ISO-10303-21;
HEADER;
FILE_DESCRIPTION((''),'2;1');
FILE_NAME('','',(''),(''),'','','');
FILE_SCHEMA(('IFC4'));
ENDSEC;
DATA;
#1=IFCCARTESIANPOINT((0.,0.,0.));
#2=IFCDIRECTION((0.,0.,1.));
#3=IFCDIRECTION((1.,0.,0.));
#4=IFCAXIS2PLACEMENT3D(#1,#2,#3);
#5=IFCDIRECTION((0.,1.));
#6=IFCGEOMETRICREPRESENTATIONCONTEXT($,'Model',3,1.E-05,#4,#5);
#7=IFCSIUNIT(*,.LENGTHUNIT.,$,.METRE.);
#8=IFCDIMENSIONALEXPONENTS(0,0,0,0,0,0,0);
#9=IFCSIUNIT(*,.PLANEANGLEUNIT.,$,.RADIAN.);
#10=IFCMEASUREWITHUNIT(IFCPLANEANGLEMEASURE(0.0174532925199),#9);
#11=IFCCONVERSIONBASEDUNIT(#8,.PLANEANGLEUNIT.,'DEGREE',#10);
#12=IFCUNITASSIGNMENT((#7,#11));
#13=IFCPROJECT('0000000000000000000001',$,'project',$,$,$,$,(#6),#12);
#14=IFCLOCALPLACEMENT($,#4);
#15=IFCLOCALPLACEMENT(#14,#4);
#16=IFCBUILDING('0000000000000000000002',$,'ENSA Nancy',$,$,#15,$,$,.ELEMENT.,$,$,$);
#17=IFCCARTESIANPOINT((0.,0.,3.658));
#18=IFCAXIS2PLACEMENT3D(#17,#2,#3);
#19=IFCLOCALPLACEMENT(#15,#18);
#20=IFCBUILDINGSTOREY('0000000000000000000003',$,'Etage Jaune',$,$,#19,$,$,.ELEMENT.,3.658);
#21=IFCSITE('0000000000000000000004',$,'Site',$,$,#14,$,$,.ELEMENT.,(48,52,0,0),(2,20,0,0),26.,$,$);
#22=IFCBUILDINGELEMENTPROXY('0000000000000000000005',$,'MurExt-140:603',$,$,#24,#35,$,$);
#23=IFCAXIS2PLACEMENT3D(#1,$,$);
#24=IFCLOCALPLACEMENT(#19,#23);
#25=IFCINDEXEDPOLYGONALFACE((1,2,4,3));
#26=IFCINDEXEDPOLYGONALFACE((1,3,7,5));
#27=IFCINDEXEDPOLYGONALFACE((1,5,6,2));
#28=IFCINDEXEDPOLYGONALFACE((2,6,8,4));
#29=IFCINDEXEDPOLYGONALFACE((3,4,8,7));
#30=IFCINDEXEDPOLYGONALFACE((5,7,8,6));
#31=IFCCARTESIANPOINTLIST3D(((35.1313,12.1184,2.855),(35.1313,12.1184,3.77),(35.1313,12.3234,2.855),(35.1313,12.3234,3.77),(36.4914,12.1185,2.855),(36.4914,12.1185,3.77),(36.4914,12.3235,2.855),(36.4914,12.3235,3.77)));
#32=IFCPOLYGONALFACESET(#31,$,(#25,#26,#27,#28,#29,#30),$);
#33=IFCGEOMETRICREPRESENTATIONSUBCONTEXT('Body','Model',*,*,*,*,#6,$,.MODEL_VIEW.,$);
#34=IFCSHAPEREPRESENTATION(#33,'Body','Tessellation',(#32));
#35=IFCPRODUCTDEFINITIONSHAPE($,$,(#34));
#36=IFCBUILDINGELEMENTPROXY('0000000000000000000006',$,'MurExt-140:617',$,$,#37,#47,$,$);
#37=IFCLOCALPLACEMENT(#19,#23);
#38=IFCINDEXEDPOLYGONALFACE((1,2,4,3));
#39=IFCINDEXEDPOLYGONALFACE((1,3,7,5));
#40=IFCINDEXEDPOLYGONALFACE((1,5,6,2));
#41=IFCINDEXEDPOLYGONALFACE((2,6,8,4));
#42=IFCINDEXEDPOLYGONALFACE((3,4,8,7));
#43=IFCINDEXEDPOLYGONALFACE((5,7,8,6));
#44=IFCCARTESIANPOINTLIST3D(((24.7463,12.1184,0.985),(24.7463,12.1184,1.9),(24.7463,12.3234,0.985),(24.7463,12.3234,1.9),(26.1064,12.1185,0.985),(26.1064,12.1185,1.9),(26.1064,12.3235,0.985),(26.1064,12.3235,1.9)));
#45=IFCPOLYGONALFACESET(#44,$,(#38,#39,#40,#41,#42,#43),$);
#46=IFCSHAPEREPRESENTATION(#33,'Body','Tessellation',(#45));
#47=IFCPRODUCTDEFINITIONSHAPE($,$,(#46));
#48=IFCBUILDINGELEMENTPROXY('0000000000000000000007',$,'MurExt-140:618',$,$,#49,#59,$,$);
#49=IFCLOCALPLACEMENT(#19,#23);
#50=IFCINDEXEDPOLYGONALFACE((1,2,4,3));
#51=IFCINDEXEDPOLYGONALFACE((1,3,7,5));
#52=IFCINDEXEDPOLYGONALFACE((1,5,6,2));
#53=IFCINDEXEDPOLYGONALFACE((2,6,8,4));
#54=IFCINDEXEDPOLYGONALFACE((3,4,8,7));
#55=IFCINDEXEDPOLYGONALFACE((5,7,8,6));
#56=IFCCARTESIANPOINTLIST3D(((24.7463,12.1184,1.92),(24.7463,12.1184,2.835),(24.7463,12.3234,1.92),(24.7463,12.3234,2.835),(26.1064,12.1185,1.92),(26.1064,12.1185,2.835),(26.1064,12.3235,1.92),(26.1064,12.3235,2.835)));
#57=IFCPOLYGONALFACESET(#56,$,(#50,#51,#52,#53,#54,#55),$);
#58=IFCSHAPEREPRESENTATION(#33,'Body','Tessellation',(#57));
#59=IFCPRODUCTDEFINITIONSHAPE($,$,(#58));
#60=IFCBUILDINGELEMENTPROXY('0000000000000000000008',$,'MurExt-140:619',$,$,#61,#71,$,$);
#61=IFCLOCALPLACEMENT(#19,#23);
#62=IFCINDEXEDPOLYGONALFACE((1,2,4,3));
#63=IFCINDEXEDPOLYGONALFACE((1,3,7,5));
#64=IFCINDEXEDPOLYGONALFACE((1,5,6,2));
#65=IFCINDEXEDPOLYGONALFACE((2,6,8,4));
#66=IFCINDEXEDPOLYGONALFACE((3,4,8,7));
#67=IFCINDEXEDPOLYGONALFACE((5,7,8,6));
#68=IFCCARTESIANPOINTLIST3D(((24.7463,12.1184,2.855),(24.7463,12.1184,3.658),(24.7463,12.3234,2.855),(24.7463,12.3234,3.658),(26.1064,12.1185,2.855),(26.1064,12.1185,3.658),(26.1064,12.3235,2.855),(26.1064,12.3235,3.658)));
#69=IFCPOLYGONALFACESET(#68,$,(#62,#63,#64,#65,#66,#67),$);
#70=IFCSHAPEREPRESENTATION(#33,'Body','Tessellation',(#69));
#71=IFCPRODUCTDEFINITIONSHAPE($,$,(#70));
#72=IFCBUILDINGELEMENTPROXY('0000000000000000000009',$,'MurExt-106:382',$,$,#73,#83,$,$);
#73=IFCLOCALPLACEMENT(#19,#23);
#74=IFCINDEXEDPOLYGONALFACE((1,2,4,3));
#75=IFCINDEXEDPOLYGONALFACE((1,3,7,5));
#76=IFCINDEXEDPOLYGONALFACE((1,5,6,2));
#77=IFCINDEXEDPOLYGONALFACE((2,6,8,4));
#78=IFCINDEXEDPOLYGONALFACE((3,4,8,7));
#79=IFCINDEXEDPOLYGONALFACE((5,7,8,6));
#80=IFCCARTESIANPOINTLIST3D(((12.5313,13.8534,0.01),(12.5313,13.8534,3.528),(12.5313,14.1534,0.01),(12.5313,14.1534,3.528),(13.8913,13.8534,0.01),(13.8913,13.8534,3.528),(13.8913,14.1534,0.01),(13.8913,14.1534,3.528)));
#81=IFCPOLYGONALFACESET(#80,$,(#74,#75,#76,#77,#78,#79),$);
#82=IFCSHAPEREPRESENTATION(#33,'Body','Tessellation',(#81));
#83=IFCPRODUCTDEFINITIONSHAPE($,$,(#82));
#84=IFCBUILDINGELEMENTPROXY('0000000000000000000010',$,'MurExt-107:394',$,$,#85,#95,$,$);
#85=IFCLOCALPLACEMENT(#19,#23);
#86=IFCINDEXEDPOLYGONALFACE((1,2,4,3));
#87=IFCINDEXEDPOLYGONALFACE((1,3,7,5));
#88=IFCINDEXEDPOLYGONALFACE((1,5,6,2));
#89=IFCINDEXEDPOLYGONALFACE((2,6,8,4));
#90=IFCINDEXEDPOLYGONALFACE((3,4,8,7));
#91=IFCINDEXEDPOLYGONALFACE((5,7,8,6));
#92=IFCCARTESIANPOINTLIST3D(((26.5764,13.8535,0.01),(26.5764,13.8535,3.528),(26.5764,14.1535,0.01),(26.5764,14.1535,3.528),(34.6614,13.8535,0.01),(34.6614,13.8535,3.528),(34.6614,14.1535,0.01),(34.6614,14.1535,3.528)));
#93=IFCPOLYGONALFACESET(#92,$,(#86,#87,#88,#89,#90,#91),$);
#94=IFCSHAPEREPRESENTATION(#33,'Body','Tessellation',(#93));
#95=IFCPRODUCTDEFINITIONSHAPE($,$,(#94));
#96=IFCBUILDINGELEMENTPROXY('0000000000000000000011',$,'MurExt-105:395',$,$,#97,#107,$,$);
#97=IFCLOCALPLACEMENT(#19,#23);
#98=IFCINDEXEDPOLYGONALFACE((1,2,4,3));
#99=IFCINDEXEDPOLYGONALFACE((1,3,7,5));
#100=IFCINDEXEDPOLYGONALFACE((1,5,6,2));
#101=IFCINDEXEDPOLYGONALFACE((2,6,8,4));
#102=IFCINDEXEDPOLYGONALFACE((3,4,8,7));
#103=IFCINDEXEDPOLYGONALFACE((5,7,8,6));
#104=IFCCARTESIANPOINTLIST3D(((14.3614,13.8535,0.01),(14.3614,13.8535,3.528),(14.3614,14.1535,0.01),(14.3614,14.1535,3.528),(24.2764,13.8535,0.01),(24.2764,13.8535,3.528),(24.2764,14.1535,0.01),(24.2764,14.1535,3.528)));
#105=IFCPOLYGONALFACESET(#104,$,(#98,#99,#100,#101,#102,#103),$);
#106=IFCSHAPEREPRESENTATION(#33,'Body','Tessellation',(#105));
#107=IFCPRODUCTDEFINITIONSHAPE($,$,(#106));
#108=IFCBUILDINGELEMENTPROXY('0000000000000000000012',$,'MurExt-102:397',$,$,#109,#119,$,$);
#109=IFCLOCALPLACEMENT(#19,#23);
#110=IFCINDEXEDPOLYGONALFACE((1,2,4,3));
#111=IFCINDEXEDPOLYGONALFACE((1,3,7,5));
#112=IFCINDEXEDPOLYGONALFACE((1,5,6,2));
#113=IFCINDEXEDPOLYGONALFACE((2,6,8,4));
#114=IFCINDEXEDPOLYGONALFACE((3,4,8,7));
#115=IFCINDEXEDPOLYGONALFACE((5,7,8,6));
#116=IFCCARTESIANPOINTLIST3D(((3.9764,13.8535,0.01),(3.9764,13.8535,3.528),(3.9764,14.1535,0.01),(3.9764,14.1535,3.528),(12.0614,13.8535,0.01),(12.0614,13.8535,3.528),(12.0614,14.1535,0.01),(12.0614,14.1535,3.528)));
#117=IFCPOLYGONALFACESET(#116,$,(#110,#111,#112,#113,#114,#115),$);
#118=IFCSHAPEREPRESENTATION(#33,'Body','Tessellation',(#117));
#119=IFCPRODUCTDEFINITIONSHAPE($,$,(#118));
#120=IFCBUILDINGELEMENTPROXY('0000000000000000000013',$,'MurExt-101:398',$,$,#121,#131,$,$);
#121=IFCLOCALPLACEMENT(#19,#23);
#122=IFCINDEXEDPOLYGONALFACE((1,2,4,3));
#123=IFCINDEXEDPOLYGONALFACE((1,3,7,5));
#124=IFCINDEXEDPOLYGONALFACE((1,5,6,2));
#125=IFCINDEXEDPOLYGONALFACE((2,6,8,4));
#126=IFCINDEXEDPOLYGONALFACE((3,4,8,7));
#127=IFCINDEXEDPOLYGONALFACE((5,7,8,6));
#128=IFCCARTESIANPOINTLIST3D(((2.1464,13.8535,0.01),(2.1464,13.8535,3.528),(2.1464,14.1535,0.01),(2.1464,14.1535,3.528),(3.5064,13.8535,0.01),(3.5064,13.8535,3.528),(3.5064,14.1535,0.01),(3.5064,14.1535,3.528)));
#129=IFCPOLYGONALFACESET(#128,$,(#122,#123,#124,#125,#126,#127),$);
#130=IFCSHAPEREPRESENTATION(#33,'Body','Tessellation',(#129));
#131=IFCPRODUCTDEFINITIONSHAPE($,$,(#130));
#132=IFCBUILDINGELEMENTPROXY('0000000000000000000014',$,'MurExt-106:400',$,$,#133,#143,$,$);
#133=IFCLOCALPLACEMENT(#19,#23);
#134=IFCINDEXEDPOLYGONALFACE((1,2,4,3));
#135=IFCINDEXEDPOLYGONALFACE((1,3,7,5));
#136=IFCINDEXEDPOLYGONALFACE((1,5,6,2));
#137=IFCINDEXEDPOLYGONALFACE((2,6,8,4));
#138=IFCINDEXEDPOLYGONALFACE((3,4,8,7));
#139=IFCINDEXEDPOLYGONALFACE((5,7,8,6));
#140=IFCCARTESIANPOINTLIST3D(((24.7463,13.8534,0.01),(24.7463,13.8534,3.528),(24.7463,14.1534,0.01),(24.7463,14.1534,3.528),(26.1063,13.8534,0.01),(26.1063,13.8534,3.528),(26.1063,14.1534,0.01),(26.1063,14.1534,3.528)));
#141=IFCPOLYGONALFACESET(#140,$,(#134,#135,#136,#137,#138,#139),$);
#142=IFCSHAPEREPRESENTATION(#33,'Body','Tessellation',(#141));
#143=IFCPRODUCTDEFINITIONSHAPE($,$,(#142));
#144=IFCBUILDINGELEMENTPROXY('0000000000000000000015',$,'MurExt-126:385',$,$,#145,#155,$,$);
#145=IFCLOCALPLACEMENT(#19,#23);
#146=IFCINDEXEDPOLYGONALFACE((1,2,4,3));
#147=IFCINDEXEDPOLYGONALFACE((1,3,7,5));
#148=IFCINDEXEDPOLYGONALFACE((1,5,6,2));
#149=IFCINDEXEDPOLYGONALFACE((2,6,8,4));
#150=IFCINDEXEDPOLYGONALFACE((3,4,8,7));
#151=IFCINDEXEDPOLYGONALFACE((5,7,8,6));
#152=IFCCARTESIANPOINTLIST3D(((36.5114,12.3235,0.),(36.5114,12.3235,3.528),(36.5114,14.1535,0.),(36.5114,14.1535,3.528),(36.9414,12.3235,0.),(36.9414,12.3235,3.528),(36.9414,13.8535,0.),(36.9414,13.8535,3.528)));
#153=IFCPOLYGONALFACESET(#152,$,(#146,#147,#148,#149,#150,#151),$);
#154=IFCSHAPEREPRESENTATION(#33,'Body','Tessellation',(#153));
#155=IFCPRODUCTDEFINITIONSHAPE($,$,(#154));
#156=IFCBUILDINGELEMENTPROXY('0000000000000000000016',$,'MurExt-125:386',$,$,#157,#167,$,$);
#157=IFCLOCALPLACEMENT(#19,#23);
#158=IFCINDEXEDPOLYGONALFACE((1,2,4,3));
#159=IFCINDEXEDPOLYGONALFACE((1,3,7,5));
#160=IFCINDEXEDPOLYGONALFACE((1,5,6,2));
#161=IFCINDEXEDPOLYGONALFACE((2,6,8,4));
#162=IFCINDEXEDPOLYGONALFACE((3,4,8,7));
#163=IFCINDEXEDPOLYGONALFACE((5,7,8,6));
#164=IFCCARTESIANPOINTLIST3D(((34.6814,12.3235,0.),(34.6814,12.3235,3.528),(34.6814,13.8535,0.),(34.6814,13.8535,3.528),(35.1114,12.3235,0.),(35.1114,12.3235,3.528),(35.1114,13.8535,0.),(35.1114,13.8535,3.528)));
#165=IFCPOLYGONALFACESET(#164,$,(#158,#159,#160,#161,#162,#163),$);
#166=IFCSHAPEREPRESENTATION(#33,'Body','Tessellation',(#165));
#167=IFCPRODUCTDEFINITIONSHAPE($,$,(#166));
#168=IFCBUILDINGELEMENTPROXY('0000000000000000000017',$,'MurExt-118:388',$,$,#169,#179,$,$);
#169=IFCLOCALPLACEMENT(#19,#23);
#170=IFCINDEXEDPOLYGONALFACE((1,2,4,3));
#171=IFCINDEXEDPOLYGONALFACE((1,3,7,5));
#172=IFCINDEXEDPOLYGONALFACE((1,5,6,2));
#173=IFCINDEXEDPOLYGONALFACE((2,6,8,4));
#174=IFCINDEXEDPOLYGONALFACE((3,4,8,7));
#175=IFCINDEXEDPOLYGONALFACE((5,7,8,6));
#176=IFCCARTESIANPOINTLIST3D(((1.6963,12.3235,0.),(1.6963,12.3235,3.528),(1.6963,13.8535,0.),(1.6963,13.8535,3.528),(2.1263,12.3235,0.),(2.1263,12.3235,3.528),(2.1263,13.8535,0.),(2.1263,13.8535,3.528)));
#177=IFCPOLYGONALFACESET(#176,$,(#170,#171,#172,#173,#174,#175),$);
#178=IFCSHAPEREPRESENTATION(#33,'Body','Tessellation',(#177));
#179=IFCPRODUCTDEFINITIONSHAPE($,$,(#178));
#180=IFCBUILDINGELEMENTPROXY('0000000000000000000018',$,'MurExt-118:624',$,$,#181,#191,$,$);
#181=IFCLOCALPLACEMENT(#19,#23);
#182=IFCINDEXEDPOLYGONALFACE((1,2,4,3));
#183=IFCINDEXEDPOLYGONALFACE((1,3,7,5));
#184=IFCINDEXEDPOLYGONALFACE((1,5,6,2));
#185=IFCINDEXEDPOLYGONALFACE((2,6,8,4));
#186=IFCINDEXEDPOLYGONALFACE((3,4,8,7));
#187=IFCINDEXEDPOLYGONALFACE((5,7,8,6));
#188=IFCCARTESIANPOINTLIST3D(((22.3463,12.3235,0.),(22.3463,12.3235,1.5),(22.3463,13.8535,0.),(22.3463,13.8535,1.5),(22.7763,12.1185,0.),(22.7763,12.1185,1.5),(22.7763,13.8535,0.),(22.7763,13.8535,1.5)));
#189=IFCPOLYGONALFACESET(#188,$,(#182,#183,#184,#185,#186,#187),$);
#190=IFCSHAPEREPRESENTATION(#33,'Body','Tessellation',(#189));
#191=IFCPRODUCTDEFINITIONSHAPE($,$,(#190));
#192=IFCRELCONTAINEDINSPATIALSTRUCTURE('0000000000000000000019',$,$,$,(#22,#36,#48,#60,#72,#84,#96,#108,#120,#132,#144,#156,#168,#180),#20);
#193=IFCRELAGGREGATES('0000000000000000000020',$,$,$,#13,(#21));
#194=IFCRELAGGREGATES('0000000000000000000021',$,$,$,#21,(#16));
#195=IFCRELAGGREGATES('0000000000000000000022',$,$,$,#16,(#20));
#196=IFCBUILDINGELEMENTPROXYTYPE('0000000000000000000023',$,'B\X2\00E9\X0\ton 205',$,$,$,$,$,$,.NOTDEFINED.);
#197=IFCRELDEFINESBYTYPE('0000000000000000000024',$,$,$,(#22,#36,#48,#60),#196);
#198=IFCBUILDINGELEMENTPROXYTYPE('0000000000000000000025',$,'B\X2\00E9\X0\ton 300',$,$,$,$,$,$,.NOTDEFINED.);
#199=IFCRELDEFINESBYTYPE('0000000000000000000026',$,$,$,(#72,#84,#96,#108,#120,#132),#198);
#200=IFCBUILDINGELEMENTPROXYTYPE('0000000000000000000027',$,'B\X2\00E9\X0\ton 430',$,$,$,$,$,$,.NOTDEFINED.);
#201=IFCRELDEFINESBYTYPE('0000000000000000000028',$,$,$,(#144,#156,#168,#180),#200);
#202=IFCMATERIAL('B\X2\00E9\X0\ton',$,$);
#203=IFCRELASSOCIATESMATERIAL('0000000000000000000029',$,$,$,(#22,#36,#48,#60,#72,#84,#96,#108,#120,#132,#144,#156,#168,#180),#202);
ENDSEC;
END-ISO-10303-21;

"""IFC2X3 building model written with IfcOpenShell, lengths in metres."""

from ifc_helpers import new_model, entity, si_unit, converted_unit, direction, frame, origin_with_axes, place, context, subcontext, project, spatial, polyline, outline, extrude, material, type_object, element, save


model = new_model("IFC2X3")

# Units and contexts
model_context = context("Model", 3, precision=1e-05, world=origin_with_axes(), true_north=direction((0.0, 1.0)))
body_context = subcontext(model_context, "Body", "Model", "MODEL_VIEW")
ifc_project = project(units=[si_unit("LENGTHUNIT", "METRE"), converted_unit("PLANEANGLEUNIT", "DEGREE", entity("IfcPlaneAngleMeasure", 0.0174532925199), si_unit("PLANEANGLEUNIT", "RADIAN"), dimensions=[0, 0, 0, 0, 0, 0, 0])], contexts=[model_context])

# Site, building, storey
site_placement = place(None, origin_with_axes())
site = spatial("IfcSite", under=ifc_project, at=site_placement, Name="Site", CompositionType="ELEMENT", RefLatitude=(48, 52, 0, 0), RefLongitude=(2, 20, 0, 0), RefElevation=26.0)
building_placement = place(site_placement, origin_with_axes())
building = spatial("IfcBuilding", under=site, at=building_placement, Name="ENSA Nancy", CompositionType="ELEMENT")
storey_placement = place(building_placement, frame((0.0, 0.0, 3.658), z_axis=(0.0, 0.0, 1.0), x_axis=(1.0, 0.0, 0.0)))
storey = spatial("IfcBuildingStorey", under=building, at=storey_placement, Name="Etage Jaune", CompositionType="ELEMENT", Elevation=3.658)

# Building element proxies
ifc_material = material(Name="Béton")
building_element_proxy_type_1 = type_object("IfcBuildingElementProxyType", Name="Béton 205", PredefinedType="NOTDEFINED")
for number, where, z_axis, x_axis, name in (
    (1, (35.1313, 12.3234, 2.855), (0.0, 0.0, 1.0), (1.0, 0.000034, 0.0), "MurExt-140:603"),
    (2, (24.7463, 12.3234, 0.985), (0.0, 0.0, 1.0), (1.0, 0.000034, 0.0), "MurExt-140:617"),
    (3, (24.7463, 12.3234, 1.92), (0.0, 0.0, 1.0), (1.0, 0.000034, 0.0), "MurExt-140:618"),
):
    element("IfcBuildingElementProxy", number, at=place(storey_placement, frame(where, z_axis=z_axis, x_axis=x_axis)), inside=storey, type_object=building_element_proxy_type_1, material=ifc_material, Name=name, context=body_context, shape_type="SweptSolid", body=[
        extrude(outline(polyline([(0.0, -0.205), (1.3601, -0.205), (1.3601, 0.0), (0.0, 0.0), (0.0, -0.205)])), origin_with_axes(), (0.0, 0.0, 1.0), 0.915),
    ])
proxy_1_placement = place(storey_placement, frame((24.7463, 12.3234, 2.855), z_axis=(0.0, 0.0, 1.0), x_axis=(1.0, 0.000034, 0.0)))
element("IfcBuildingElementProxy", 4, at=proxy_1_placement, inside=storey, type_object=building_element_proxy_type_1, material=ifc_material, Name="MurExt-140:619", context=body_context, shape_type="SweptSolid", body=[
    extrude(outline(polyline([(0.0, -0.205), (1.3601, -0.205), (1.3601, 0.0), (0.0, 0.0), (0.0, -0.205)])), origin_with_axes(), (0.0, 0.0, 1.0), 0.803),
])
building_element_proxy_type_2 = type_object("IfcBuildingElementProxyType", Name="Béton 300", PredefinedType="NOTDEFINED")
proxy_2_placement = place(storey_placement, frame((12.5313, 13.8534, 0.01), z_axis=(0.0, 0.0, 1.0), x_axis=(1.0, 0.0, 0.0)))
element("IfcBuildingElementProxy", 5, at=proxy_2_placement, inside=storey, type_object=building_element_proxy_type_2, material=ifc_material, Name="MurExt-106:382", context=body_context, shape_type="SweptSolid", body=[
    extrude(outline(polyline([(0.0, 0.0), (1.36, 0.0), (1.36, 0.3), (0.0, 0.3), (0.0, 0.0)])), origin_with_axes(), (0.0, 0.0, 1.0), 3.518),
])
proxy_3_placement = place(storey_placement, frame((26.5764, 13.8535, 0.01), z_axis=(0.0, 0.0, 1.0), x_axis=(1.0, 0.0, 0.0)))
element("IfcBuildingElementProxy", 6, at=proxy_3_placement, inside=storey, type_object=building_element_proxy_type_2, material=ifc_material, Name="MurExt-107:394", context=body_context, shape_type="SweptSolid", body=[
    extrude(outline(polyline([(0.0, 0.0), (8.085, 0.0), (8.085, 0.3), (0.0, 0.3), (0.0, 0.0)])), origin_with_axes(), (0.0, 0.0, 1.0), 3.518),
])
proxy_4_placement = place(storey_placement, frame((14.3614, 13.8535, 0.01), z_axis=(0.0, 0.0, 1.0), x_axis=(1.0, 0.0, 0.0)))
element("IfcBuildingElementProxy", 7, at=proxy_4_placement, inside=storey, type_object=building_element_proxy_type_2, material=ifc_material, Name="MurExt-105:395", context=body_context, shape_type="SweptSolid", body=[
    extrude(outline(polyline([(0.0, 0.0), (9.915, 0.0), (9.915, 0.3), (0.0, 0.3), (0.0, 0.0)])), origin_with_axes(), (0.0, 0.0, 1.0), 3.518),
])
proxy_5_placement = place(storey_placement, frame((3.9764, 13.8535, 0.01), z_axis=(0.0, 0.0, 1.0), x_axis=(1.0, 0.000001, 0.0)))
element("IfcBuildingElementProxy", 8, at=proxy_5_placement, inside=storey, type_object=building_element_proxy_type_2, material=ifc_material, Name="MurExt-102:397", context=body_context, shape_type="SweptSolid", body=[
    extrude(outline(polyline([(0.0, 0.0), (8.085, 0.0), (8.085, 0.3), (0.0, 0.3), (0.0, 0.0)])), origin_with_axes(), (0.0, 0.0, 1.0), 3.518),
])
proxy_6_placement = place(storey_placement, frame((2.1464, 13.8535, 0.01), z_axis=(0.0, 0.0, 1.0), x_axis=(1.0, 0.0, 0.0)))
element("IfcBuildingElementProxy", 9, at=proxy_6_placement, inside=storey, type_object=building_element_proxy_type_2, material=ifc_material, Name="MurExt-101:398", context=body_context, shape_type="SweptSolid", body=[
    extrude(outline(polyline([(0.0, 0.0), (1.36, 0.0), (1.36, 0.3), (0.0, 0.3), (0.0, 0.0)])), origin_with_axes(), (0.0, 0.0, 1.0), 3.518),
])
proxy_7_placement = place(storey_placement, frame((24.7463, 13.8534, 0.01), z_axis=(0.0, 0.0, 1.0), x_axis=(1.0, 0.0, 0.0)))
element("IfcBuildingElementProxy", 10, at=proxy_7_placement, inside=storey, type_object=building_element_proxy_type_2, material=ifc_material, Name="MurExt-106:400", context=body_context, shape_type="SweptSolid", body=[
    extrude(outline(polyline([(0.0, 0.0), (1.36, 0.0), (1.36, 0.3), (0.0, 0.3), (0.0, 0.0)])), origin_with_axes(), (0.0, 0.0, 1.0), 3.518),
])
building_element_proxy_type_3 = type_object("IfcBuildingElementProxyType", Name="Béton 430", PredefinedType="NOTDEFINED")
proxy_8_placement = place(storey_placement, frame((36.5114, 13.8535, 0.0), z_axis=(0.0, 0.0, 1.0), x_axis=(0.0, -1.0, 0.0)))
element("IfcBuildingElementProxy", 11, at=proxy_8_placement, inside=storey, type_object=building_element_proxy_type_3, material=ifc_material, Name="MurExt-126:385", context=body_context, shape_type="SweptSolid", body=[
    extrude(outline(polyline([(-0.3, 0.0), (1.53, 0.0), (1.53, 0.43), (0.0, 0.43), (-0.3, 0.0)])), origin_with_axes(), (0.0, 0.0, 1.0), 3.528),
])
proxy_9_placement = place(storey_placement, frame((34.6814, 13.8535, 0.0), z_axis=(0.0, 0.0, 1.0), x_axis=(0.0, -1.0, 0.0)))
element("IfcBuildingElementProxy", 12, at=proxy_9_placement, inside=storey, type_object=building_element_proxy_type_3, material=ifc_material, Name="MurExt-125:386", context=body_context, shape_type="SweptSolid", body=[
    extrude(outline(polyline([(0.0, 0.0), (1.53, 0.0), (1.53, 0.43), (0.0, 0.43), (0.0, 0.0)])), origin_with_axes(), (0.0, 0.0, 1.0), 3.528),
])
proxy_10_placement = place(storey_placement, frame((1.6963, 13.8535, 0.0), z_axis=(0.0, 0.0, 1.0), x_axis=(0.0, -1.0, 0.0)))
element("IfcBuildingElementProxy", 13, at=proxy_10_placement, inside=storey, type_object=building_element_proxy_type_3, material=ifc_material, Name="MurExt-118:388", context=body_context, shape_type="SweptSolid", body=[
    extrude(outline(polyline([(0.0, 0.0), (1.53, 0.0), (1.53, 0.43), (0.0, 0.43), (0.0, 0.0)])), origin_with_axes(), (0.0, 0.0, 1.0), 3.528),
])
proxy_11_placement = place(storey_placement, frame((22.3463, 13.8535, 0.0), z_axis=(0.0, 0.0, 1.0), x_axis=(0.0, -1.0, 0.0)))
element("IfcBuildingElementProxy", 14, at=proxy_11_placement, inside=storey, type_object=building_element_proxy_type_3, material=ifc_material, Name="MurExt-118:624", context=body_context, shape_type="SweptSolid", body=[
    extrude(outline(polyline([(0.0, 0.0), (1.53, 0.0), (1.735, 0.43), (0.0, 0.43), (0.0, 0.0)])), origin_with_axes(), (0.0, 0.0, 1.0), 1.5),
])

save(model, "model.ifc")
